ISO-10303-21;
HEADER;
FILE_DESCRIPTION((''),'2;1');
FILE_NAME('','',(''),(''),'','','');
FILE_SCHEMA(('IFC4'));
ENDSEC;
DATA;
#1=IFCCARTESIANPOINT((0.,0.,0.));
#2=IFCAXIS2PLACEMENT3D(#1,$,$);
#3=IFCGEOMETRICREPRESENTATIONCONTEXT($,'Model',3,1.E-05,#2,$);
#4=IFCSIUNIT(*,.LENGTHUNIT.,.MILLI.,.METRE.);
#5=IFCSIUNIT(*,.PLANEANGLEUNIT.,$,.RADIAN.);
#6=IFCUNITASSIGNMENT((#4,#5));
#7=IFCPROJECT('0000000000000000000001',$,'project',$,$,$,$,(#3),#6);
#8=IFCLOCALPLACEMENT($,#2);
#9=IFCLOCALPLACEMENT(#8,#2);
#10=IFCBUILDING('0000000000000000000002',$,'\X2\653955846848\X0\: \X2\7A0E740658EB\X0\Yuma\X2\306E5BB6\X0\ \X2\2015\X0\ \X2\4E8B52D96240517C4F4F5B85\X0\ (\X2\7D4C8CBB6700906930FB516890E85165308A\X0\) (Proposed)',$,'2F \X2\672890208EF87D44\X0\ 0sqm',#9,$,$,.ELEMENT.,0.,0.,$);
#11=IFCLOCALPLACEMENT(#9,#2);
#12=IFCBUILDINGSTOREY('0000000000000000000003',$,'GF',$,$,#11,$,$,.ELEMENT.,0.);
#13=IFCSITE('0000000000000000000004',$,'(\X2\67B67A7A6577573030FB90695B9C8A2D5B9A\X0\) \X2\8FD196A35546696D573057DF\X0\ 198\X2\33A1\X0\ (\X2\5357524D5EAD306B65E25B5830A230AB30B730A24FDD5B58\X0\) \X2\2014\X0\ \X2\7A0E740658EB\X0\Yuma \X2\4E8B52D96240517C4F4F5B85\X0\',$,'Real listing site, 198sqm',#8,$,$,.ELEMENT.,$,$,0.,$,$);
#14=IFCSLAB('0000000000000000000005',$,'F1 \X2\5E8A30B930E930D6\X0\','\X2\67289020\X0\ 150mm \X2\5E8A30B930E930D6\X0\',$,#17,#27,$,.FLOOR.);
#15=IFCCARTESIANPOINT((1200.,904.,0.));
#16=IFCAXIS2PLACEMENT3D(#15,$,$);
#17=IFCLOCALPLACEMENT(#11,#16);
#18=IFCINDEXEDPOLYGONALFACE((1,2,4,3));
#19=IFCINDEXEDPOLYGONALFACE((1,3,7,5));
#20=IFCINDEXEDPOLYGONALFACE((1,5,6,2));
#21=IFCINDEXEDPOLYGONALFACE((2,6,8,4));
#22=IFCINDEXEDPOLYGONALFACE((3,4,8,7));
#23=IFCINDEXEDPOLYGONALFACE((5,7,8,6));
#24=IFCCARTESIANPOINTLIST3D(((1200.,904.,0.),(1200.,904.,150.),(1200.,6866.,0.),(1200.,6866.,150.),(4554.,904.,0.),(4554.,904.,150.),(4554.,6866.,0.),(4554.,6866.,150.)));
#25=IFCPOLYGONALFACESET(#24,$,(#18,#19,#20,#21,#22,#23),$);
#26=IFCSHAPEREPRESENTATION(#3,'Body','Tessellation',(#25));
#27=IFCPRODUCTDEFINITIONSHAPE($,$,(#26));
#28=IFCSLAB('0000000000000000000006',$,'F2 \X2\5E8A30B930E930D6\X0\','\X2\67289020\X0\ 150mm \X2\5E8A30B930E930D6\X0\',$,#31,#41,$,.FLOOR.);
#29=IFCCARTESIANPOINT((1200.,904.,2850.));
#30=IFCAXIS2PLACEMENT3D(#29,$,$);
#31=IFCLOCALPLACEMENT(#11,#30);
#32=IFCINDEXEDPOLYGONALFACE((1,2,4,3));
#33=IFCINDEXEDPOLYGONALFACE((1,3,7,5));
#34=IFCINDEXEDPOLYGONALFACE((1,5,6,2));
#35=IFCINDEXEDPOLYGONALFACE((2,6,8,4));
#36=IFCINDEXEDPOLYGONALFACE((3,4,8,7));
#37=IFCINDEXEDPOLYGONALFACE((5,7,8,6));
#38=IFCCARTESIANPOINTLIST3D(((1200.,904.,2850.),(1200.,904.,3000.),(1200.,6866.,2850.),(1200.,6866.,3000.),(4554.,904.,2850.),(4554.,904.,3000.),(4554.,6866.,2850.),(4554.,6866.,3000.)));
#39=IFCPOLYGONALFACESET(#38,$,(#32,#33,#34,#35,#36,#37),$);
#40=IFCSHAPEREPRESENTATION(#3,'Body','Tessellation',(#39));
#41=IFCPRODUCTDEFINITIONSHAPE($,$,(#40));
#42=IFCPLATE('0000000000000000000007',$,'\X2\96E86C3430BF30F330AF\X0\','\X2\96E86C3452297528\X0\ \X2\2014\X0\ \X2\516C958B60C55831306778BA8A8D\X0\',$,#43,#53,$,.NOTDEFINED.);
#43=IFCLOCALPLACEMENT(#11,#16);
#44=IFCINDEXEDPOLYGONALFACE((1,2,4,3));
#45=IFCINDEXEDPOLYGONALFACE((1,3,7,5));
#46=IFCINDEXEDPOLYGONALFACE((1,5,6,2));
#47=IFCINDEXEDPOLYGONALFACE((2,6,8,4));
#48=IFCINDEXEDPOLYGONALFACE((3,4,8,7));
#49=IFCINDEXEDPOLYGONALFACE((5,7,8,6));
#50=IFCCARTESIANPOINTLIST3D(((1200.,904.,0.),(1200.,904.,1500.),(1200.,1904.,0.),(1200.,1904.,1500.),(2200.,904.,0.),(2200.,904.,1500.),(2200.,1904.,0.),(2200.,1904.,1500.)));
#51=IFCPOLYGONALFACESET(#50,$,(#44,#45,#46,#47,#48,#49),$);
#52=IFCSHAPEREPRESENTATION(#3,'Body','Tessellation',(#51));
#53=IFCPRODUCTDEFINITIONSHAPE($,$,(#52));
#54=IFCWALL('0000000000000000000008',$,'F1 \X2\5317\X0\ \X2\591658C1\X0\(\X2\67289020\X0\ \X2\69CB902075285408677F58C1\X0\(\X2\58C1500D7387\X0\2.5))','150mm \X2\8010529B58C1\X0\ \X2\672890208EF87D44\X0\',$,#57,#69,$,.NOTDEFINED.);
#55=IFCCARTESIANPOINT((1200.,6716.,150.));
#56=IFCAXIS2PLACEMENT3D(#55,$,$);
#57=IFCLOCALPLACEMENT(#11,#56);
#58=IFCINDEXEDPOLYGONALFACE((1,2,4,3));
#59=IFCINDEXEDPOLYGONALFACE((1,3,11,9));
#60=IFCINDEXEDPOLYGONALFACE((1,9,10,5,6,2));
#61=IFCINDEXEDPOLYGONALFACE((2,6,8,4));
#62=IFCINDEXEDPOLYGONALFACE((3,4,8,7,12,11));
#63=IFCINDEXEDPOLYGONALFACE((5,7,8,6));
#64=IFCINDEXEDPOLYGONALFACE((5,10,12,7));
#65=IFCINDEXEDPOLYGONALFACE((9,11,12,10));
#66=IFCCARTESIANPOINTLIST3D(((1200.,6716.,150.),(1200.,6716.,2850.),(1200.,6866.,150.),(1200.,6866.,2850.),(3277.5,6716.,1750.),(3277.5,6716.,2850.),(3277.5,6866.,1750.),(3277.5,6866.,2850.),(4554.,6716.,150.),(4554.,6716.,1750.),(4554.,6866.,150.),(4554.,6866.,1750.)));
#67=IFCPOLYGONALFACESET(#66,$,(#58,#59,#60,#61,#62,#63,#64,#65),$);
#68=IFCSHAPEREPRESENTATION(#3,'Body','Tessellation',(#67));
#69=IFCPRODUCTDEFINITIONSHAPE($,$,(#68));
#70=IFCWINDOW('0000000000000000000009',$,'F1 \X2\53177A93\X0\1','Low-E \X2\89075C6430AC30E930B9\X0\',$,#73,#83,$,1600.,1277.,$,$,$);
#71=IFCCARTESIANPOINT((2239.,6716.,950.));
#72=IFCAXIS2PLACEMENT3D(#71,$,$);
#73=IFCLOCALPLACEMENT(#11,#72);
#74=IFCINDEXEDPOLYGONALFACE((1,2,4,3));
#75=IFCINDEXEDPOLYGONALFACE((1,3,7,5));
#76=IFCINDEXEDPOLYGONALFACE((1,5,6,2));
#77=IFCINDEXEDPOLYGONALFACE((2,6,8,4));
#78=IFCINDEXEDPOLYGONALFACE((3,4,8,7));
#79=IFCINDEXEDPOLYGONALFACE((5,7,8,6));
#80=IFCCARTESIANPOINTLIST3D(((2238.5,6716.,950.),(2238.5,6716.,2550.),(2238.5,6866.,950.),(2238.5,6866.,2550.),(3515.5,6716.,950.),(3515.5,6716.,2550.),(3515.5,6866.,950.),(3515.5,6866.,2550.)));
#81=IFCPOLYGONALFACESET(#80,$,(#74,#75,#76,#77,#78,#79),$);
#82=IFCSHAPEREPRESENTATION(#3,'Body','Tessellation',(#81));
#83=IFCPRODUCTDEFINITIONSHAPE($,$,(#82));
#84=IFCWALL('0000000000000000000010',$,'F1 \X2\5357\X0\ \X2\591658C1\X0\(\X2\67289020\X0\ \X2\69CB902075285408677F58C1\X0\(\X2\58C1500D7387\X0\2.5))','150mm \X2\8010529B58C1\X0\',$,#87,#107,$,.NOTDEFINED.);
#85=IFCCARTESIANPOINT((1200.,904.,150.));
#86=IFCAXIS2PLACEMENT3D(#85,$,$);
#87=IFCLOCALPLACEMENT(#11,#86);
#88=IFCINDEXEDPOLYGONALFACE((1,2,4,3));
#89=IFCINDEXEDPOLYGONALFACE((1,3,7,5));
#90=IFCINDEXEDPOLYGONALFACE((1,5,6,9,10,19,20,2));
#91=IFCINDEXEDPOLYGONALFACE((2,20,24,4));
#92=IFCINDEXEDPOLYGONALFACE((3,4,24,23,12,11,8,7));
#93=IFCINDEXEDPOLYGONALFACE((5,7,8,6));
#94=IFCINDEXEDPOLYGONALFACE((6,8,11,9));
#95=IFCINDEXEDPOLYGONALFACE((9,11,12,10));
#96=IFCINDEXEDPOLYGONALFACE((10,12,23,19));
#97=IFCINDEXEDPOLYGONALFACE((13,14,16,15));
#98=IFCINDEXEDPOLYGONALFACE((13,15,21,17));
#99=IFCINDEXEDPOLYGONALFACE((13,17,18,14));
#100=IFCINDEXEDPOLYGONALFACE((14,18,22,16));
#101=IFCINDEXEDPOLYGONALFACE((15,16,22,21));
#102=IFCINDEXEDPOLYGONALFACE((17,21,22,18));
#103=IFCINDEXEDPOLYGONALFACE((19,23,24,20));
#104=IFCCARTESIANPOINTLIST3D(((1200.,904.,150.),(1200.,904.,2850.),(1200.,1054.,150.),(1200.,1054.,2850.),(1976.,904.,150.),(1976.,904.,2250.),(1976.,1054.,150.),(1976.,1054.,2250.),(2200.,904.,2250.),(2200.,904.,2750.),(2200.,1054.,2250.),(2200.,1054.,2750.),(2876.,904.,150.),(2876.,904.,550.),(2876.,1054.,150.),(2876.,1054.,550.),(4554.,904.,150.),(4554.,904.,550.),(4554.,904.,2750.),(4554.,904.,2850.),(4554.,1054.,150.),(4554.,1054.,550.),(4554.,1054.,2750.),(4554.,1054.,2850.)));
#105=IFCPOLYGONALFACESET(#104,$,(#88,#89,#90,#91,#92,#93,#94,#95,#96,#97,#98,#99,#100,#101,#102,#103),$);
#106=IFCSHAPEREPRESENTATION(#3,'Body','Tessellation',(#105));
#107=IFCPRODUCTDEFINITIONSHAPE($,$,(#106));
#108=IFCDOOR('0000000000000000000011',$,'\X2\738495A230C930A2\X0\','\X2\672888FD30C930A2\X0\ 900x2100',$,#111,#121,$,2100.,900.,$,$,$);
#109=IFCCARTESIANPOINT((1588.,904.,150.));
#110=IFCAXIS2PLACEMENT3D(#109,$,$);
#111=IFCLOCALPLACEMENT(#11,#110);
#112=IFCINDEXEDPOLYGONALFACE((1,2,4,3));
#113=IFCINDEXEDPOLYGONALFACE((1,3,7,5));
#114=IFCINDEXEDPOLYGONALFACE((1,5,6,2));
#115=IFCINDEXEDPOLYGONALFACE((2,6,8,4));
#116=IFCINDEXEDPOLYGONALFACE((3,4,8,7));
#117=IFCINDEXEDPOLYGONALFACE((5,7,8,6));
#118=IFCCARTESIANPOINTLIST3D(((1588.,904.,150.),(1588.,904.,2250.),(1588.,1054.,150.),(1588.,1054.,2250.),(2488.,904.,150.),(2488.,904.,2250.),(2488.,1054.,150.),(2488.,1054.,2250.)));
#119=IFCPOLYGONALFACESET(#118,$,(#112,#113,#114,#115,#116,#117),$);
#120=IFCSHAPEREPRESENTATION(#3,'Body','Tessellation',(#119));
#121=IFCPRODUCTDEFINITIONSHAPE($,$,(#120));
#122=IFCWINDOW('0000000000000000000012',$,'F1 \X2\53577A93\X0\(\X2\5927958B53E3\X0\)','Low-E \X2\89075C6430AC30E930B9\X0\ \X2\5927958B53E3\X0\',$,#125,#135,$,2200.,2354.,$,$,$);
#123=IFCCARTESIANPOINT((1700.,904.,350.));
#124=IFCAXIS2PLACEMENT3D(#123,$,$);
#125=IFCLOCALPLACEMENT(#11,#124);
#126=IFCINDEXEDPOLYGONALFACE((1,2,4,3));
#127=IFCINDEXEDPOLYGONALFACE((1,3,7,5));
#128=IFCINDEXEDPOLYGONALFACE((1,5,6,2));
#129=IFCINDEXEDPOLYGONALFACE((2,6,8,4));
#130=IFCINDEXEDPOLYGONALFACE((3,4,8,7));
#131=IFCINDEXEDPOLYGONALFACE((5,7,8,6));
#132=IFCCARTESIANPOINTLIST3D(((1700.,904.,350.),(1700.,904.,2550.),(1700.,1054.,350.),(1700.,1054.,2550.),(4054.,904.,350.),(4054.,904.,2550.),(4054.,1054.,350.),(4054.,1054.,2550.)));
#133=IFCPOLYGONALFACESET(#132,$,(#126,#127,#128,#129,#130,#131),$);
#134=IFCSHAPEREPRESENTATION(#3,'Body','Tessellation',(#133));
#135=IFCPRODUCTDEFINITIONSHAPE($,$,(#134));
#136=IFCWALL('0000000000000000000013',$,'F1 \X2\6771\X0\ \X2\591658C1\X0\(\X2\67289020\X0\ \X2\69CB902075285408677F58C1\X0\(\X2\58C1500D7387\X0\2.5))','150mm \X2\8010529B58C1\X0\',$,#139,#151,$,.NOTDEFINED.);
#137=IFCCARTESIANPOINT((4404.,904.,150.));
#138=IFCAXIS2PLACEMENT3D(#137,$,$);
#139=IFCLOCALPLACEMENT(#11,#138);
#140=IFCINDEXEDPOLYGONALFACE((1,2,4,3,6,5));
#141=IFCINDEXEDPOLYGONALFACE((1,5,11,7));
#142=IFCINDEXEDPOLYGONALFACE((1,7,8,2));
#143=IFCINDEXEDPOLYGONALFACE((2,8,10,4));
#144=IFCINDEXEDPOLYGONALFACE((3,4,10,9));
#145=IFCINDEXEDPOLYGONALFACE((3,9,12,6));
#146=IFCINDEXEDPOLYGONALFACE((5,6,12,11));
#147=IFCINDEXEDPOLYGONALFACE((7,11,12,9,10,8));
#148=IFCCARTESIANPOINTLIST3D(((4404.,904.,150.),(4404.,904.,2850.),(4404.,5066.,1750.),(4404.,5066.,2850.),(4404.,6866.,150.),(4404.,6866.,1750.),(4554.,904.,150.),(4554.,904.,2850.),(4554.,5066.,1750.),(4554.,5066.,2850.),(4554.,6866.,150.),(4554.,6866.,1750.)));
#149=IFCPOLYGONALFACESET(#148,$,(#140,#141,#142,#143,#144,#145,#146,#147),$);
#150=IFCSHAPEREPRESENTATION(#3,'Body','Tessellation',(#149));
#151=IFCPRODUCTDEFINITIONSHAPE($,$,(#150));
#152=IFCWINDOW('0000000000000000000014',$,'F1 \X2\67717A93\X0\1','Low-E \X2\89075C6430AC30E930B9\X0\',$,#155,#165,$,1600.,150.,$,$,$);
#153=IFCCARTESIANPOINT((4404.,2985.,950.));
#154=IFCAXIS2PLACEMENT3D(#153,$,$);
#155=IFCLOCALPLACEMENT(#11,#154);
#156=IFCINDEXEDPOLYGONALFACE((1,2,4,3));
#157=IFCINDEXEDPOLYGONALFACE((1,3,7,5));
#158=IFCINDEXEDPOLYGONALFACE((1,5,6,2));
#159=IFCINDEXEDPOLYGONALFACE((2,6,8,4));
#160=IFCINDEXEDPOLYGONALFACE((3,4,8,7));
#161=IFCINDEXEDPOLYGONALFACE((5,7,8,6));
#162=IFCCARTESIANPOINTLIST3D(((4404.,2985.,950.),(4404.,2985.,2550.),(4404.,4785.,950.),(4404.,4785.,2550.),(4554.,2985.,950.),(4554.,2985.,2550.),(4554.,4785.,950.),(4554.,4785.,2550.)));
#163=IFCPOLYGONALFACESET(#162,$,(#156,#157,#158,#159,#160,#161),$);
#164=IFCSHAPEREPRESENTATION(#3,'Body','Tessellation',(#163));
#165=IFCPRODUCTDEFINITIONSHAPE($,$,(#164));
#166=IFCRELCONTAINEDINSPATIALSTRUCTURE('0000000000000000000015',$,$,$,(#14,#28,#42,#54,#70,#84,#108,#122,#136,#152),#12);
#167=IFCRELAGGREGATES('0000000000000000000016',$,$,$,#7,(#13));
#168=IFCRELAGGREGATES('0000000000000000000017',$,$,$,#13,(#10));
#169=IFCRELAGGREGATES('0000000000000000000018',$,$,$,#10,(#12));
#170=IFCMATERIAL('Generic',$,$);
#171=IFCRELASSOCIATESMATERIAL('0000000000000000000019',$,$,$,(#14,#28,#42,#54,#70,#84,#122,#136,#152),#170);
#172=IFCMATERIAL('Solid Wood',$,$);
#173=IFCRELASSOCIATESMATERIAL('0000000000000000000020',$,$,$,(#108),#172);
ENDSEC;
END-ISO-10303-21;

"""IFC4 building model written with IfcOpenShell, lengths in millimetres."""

from ifc_helpers import new_model, si_unit, frame, frame_2d, origin, place, context, project, spatial, rectangle, extrude, material, element, fill, save


model = new_model("IFC4")

# Units and contexts
model_context = context("Model", 3, precision=1e-05, world=origin())
ifc_project = project(units=[si_unit("LENGTHUNIT", "METRE", prefix="MILLI"), si_unit("PLANEANGLEUNIT", "RADIAN")], contexts=[model_context])

# Site, building, storey
site_placement = place(None, origin())
site = spatial("IfcSite", under=ifc_project, at=site_placement, Name="(架空敷地・適宜設定) 近隣商業地域 198㎡ (南前庭に既存アカシア保存) — 税理士Yuma 事務所兼住宅", ObjectType="Real listing site, 198sqm", CompositionType="ELEMENT", RefElevation=0.0)
building_placement = place(site_placement, origin())
building = spatial("IfcBuilding", under=site, at=building_placement, Name="改善案: 税理士Yumaの家 ― 事務所兼住宅 (経費最適・全部入り) (Proposed)", ObjectType="2F 木造軸組 0sqm", CompositionType="ELEMENT", ElevationOfRefHeight=0.0, ElevationOfTerrain=0.0)
storey_placement = place(building_placement, origin())
storey = spatial("IfcBuildingStorey", under=building, at=storey_placement, Name="GF", CompositionType="ELEMENT", Elevation=0.0)

# Slabs
ifc_material_1 = material(Name="Generic")
slab_1_placement = place(storey_placement, frame((1200.0, 904.0, 0.0)))
element("IfcSlab", 1, at=slab_1_placement, inside=storey, material=ifc_material_1, Name="F1 床スラブ", Description="木造 150mm 床スラブ", PredefinedType="FLOOR", context=model_context, shape_type="SweptSolid", body=[
    extrude(rectangle(XDim=3354.0, YDim=5962.0, at=frame_2d((1677.0, 2981.0))), frame((1200.0, 904.0, 0.0)), (0.0, 0.0, 1.0), 150.0),
])
slab_2_placement = place(storey_placement, frame((1200.0, 904.0, 2850.0)))
element("IfcSlab", 2, at=slab_2_placement, inside=storey, material=ifc_material_1, Name="F2 床スラブ", Description="木造 150mm 床スラブ", PredefinedType="FLOOR", context=model_context, shape_type="SweptSolid", body=[
    extrude(rectangle(XDim=3354.0, YDim=5962.0, at=frame_2d((1677.0, 2981.0))), frame((1200.0, 904.0, 2850.0)), (0.0, 0.0, 1.0), 150.0),
])

# Plate
plate_placement = place(storey_placement, frame((1200.0, 904.0, 0.0)))
element("IfcPlate", 3, at=plate_placement, inside=storey, material=ifc_material_1, Name="雨水タンク", Description="雨水利用 — 公開情報で確認", PredefinedType="NOTDEFINED", context=model_context, shape_type="SweptSolid", body=[
    extrude(rectangle(XDim=1000.0, YDim=1000.0, at=frame_2d((500.0, 500.0))), frame((1200.0, 904.0, 0.0)), (0.0, 0.0, 1.0), 1500.0),
])

# Wall, opening, window
wall_1_placement = place(storey_placement, frame((1200.0, 6716.0, 150.0)))
wall_1 = element("IfcWall", 4, at=wall_1_placement, inside=storey, material=ifc_material_1, Name="F1 北 外壁(木造 構造用合板壁(壁倍率2.5))", Description="150mm 耐力壁 木造軸組", PredefinedType="NOTDEFINED", context=model_context, shape_type="SweptSolid", body=[
    extrude(rectangle(XDim=3354.0, YDim=150.0, at=frame_2d((1677.0, 75.0))), frame((1200.0, 6716.0, 150.0)), (0.0, 0.0, 1.0), 2700.0),
])
opening_1_placement = place(storey_placement, frame((2239.0, 6716.0, 950.0)))
opening_1 = element("IfcOpeningElement", 5, at=opening_1_placement, cuts=wall_1, PredefinedType="NOTDEFINED", context=model_context, shape_type="SweptSolid", body=[
    extrude(rectangle(XDim=1277.0, YDim=150.0, at=frame_2d((638.0, 75.0))), frame((2239.0, 6716.0, 950.0)), (0.0, 0.0, 1.0), 1600.0),
])
window_1_placement = place(storey_placement, frame((2239.0, 6716.0, 950.0)))
window_1 = element("IfcWindow", 6, at=window_1_placement, inside=storey, material=ifc_material_1, Name="F1 北窓1", Description="Low-E 複層ガラス", OverallHeight=1600.0, OverallWidth=1277.0, context=model_context, shape_type="SweptSolid", body=[
    extrude(rectangle(XDim=1277.0, YDim=150.0, at=frame_2d((638.0, 75.0))), frame((2239.0, 6716.0, 950.0)), (0.0, 0.0, 1.0), 1600.0),
])
fill(opening_1, window_1)

# Wall, openings, door, window
wall_2_placement = place(storey_placement, frame((1200.0, 904.0, 150.0)))
wall_2 = element("IfcWall", 7, at=wall_2_placement, inside=storey, material=ifc_material_1, Name="F1 南 外壁(木造 構造用合板壁(壁倍率2.5))", Description="150mm 耐力壁", PredefinedType="NOTDEFINED", context=model_context, shape_type="SweptSolid", body=[
    extrude(rectangle(XDim=3354.0, YDim=150.0, at=frame_2d((1677.0, 75.0))), frame((1200.0, 904.0, 150.0)), (0.0, 0.0, 1.0), 2700.0),
])
opening_2_placement = place(storey_placement, frame((1588.0, 904.0, 150.0)))
opening_2 = element("IfcOpeningElement", 8, at=opening_2_placement, cuts=wall_2, PredefinedType="NOTDEFINED", context=model_context, shape_type="SweptSolid", body=[
    extrude(rectangle(XDim=900.0, YDim=150.0, at=frame_2d((450.0, 75.0))), frame((1588.0, 904.0, 150.0)), (0.0, 0.0, 1.0), 2100.0),
])
opening_3_placement = place(storey_placement, frame((1700.0, 904.0, 350.0)))
opening_3 = element("IfcOpeningElement", 9, at=opening_3_placement, cuts=wall_2, PredefinedType="NOTDEFINED", context=model_context, shape_type="SweptSolid", body=[
    extrude(rectangle(XDim=2354.0, YDim=150.0, at=frame_2d((1177.0, 75.0))), frame((1700.0, 904.0, 350.0)), (0.0, 0.0, 1.0), 2200.0),
])
ifc_material_2 = material(Name="Solid Wood")
door_placement = place(storey_placement, frame((1588.0, 904.0, 150.0)))
door = element("IfcDoor", 10, at=door_placement, inside=storey, material=ifc_material_2, Name="玄関ドア", Description="木製ドア 900x2100", OverallHeight=2100.0, OverallWidth=900.0, context=model_context, shape_type="SweptSolid", body=[
    extrude(rectangle(XDim=900.0, YDim=150.0, at=frame_2d((450.0, 75.0))), frame((1588.0, 904.0, 150.0)), (0.0, 0.0, 1.0), 2100.0),
])
fill(opening_2, door)
window_2_placement = place(storey_placement, frame((1700.0, 904.0, 350.0)))
window_2 = element("IfcWindow", 11, at=window_2_placement, inside=storey, material=ifc_material_1, Name="F1 南窓(大開口)", Description="Low-E 複層ガラス 大開口", OverallHeight=2200.0, OverallWidth=2354.0, context=model_context, shape_type="SweptSolid", body=[
    extrude(rectangle(XDim=2354.0, YDim=150.0, at=frame_2d((1177.0, 75.0))), frame((1700.0, 904.0, 350.0)), (0.0, 0.0, 1.0), 2200.0),
])
fill(opening_3, window_2)

# Wall, opening, window
wall_3_placement = place(storey_placement, frame((4404.0, 904.0, 150.0)))
wall_3 = element("IfcWall", 12, at=wall_3_placement, inside=storey, material=ifc_material_1, Name="F1 東 外壁(木造 構造用合板壁(壁倍率2.5))", Description="150mm 耐力壁", PredefinedType="NOTDEFINED", context=model_context, shape_type="SweptSolid", body=[
    extrude(rectangle(XDim=150.0, YDim=5962.0, at=frame_2d((75.0, 2981.0))), frame((4404.0, 904.0, 150.0)), (0.0, 0.0, 1.0), 2700.0),
])
opening_4_placement = place(storey_placement, frame((4404.0, 2985.0, 950.0)))
opening_4 = element("IfcOpeningElement", 13, at=opening_4_placement, cuts=wall_3, PredefinedType="NOTDEFINED", context=model_context, shape_type="SweptSolid", body=[
    extrude(rectangle(XDim=150.0, YDim=1800.0, at=frame_2d((75.0, 900.0))), frame((4404.0, 2985.0, 950.0)), (0.0, 0.0, 1.0), 1600.0),
])
window_3_placement = place(storey_placement, frame((4404.0, 2985.0, 950.0)))
window_3 = element("IfcWindow", 14, at=window_3_placement, inside=storey, material=ifc_material_1, Name="F1 東窓1", Description="Low-E 複層ガラス", OverallHeight=1600.0, OverallWidth=150.0, context=model_context, shape_type="SweptSolid", body=[
    extrude(rectangle(XDim=150.0, YDim=1800.0, at=frame_2d((75.0, 900.0))), frame((4404.0, 2985.0, 950.0)), (0.0, 0.0, 1.0), 1600.0),
])
fill(opening_4, window_3)

save(model, "model.ifc")
